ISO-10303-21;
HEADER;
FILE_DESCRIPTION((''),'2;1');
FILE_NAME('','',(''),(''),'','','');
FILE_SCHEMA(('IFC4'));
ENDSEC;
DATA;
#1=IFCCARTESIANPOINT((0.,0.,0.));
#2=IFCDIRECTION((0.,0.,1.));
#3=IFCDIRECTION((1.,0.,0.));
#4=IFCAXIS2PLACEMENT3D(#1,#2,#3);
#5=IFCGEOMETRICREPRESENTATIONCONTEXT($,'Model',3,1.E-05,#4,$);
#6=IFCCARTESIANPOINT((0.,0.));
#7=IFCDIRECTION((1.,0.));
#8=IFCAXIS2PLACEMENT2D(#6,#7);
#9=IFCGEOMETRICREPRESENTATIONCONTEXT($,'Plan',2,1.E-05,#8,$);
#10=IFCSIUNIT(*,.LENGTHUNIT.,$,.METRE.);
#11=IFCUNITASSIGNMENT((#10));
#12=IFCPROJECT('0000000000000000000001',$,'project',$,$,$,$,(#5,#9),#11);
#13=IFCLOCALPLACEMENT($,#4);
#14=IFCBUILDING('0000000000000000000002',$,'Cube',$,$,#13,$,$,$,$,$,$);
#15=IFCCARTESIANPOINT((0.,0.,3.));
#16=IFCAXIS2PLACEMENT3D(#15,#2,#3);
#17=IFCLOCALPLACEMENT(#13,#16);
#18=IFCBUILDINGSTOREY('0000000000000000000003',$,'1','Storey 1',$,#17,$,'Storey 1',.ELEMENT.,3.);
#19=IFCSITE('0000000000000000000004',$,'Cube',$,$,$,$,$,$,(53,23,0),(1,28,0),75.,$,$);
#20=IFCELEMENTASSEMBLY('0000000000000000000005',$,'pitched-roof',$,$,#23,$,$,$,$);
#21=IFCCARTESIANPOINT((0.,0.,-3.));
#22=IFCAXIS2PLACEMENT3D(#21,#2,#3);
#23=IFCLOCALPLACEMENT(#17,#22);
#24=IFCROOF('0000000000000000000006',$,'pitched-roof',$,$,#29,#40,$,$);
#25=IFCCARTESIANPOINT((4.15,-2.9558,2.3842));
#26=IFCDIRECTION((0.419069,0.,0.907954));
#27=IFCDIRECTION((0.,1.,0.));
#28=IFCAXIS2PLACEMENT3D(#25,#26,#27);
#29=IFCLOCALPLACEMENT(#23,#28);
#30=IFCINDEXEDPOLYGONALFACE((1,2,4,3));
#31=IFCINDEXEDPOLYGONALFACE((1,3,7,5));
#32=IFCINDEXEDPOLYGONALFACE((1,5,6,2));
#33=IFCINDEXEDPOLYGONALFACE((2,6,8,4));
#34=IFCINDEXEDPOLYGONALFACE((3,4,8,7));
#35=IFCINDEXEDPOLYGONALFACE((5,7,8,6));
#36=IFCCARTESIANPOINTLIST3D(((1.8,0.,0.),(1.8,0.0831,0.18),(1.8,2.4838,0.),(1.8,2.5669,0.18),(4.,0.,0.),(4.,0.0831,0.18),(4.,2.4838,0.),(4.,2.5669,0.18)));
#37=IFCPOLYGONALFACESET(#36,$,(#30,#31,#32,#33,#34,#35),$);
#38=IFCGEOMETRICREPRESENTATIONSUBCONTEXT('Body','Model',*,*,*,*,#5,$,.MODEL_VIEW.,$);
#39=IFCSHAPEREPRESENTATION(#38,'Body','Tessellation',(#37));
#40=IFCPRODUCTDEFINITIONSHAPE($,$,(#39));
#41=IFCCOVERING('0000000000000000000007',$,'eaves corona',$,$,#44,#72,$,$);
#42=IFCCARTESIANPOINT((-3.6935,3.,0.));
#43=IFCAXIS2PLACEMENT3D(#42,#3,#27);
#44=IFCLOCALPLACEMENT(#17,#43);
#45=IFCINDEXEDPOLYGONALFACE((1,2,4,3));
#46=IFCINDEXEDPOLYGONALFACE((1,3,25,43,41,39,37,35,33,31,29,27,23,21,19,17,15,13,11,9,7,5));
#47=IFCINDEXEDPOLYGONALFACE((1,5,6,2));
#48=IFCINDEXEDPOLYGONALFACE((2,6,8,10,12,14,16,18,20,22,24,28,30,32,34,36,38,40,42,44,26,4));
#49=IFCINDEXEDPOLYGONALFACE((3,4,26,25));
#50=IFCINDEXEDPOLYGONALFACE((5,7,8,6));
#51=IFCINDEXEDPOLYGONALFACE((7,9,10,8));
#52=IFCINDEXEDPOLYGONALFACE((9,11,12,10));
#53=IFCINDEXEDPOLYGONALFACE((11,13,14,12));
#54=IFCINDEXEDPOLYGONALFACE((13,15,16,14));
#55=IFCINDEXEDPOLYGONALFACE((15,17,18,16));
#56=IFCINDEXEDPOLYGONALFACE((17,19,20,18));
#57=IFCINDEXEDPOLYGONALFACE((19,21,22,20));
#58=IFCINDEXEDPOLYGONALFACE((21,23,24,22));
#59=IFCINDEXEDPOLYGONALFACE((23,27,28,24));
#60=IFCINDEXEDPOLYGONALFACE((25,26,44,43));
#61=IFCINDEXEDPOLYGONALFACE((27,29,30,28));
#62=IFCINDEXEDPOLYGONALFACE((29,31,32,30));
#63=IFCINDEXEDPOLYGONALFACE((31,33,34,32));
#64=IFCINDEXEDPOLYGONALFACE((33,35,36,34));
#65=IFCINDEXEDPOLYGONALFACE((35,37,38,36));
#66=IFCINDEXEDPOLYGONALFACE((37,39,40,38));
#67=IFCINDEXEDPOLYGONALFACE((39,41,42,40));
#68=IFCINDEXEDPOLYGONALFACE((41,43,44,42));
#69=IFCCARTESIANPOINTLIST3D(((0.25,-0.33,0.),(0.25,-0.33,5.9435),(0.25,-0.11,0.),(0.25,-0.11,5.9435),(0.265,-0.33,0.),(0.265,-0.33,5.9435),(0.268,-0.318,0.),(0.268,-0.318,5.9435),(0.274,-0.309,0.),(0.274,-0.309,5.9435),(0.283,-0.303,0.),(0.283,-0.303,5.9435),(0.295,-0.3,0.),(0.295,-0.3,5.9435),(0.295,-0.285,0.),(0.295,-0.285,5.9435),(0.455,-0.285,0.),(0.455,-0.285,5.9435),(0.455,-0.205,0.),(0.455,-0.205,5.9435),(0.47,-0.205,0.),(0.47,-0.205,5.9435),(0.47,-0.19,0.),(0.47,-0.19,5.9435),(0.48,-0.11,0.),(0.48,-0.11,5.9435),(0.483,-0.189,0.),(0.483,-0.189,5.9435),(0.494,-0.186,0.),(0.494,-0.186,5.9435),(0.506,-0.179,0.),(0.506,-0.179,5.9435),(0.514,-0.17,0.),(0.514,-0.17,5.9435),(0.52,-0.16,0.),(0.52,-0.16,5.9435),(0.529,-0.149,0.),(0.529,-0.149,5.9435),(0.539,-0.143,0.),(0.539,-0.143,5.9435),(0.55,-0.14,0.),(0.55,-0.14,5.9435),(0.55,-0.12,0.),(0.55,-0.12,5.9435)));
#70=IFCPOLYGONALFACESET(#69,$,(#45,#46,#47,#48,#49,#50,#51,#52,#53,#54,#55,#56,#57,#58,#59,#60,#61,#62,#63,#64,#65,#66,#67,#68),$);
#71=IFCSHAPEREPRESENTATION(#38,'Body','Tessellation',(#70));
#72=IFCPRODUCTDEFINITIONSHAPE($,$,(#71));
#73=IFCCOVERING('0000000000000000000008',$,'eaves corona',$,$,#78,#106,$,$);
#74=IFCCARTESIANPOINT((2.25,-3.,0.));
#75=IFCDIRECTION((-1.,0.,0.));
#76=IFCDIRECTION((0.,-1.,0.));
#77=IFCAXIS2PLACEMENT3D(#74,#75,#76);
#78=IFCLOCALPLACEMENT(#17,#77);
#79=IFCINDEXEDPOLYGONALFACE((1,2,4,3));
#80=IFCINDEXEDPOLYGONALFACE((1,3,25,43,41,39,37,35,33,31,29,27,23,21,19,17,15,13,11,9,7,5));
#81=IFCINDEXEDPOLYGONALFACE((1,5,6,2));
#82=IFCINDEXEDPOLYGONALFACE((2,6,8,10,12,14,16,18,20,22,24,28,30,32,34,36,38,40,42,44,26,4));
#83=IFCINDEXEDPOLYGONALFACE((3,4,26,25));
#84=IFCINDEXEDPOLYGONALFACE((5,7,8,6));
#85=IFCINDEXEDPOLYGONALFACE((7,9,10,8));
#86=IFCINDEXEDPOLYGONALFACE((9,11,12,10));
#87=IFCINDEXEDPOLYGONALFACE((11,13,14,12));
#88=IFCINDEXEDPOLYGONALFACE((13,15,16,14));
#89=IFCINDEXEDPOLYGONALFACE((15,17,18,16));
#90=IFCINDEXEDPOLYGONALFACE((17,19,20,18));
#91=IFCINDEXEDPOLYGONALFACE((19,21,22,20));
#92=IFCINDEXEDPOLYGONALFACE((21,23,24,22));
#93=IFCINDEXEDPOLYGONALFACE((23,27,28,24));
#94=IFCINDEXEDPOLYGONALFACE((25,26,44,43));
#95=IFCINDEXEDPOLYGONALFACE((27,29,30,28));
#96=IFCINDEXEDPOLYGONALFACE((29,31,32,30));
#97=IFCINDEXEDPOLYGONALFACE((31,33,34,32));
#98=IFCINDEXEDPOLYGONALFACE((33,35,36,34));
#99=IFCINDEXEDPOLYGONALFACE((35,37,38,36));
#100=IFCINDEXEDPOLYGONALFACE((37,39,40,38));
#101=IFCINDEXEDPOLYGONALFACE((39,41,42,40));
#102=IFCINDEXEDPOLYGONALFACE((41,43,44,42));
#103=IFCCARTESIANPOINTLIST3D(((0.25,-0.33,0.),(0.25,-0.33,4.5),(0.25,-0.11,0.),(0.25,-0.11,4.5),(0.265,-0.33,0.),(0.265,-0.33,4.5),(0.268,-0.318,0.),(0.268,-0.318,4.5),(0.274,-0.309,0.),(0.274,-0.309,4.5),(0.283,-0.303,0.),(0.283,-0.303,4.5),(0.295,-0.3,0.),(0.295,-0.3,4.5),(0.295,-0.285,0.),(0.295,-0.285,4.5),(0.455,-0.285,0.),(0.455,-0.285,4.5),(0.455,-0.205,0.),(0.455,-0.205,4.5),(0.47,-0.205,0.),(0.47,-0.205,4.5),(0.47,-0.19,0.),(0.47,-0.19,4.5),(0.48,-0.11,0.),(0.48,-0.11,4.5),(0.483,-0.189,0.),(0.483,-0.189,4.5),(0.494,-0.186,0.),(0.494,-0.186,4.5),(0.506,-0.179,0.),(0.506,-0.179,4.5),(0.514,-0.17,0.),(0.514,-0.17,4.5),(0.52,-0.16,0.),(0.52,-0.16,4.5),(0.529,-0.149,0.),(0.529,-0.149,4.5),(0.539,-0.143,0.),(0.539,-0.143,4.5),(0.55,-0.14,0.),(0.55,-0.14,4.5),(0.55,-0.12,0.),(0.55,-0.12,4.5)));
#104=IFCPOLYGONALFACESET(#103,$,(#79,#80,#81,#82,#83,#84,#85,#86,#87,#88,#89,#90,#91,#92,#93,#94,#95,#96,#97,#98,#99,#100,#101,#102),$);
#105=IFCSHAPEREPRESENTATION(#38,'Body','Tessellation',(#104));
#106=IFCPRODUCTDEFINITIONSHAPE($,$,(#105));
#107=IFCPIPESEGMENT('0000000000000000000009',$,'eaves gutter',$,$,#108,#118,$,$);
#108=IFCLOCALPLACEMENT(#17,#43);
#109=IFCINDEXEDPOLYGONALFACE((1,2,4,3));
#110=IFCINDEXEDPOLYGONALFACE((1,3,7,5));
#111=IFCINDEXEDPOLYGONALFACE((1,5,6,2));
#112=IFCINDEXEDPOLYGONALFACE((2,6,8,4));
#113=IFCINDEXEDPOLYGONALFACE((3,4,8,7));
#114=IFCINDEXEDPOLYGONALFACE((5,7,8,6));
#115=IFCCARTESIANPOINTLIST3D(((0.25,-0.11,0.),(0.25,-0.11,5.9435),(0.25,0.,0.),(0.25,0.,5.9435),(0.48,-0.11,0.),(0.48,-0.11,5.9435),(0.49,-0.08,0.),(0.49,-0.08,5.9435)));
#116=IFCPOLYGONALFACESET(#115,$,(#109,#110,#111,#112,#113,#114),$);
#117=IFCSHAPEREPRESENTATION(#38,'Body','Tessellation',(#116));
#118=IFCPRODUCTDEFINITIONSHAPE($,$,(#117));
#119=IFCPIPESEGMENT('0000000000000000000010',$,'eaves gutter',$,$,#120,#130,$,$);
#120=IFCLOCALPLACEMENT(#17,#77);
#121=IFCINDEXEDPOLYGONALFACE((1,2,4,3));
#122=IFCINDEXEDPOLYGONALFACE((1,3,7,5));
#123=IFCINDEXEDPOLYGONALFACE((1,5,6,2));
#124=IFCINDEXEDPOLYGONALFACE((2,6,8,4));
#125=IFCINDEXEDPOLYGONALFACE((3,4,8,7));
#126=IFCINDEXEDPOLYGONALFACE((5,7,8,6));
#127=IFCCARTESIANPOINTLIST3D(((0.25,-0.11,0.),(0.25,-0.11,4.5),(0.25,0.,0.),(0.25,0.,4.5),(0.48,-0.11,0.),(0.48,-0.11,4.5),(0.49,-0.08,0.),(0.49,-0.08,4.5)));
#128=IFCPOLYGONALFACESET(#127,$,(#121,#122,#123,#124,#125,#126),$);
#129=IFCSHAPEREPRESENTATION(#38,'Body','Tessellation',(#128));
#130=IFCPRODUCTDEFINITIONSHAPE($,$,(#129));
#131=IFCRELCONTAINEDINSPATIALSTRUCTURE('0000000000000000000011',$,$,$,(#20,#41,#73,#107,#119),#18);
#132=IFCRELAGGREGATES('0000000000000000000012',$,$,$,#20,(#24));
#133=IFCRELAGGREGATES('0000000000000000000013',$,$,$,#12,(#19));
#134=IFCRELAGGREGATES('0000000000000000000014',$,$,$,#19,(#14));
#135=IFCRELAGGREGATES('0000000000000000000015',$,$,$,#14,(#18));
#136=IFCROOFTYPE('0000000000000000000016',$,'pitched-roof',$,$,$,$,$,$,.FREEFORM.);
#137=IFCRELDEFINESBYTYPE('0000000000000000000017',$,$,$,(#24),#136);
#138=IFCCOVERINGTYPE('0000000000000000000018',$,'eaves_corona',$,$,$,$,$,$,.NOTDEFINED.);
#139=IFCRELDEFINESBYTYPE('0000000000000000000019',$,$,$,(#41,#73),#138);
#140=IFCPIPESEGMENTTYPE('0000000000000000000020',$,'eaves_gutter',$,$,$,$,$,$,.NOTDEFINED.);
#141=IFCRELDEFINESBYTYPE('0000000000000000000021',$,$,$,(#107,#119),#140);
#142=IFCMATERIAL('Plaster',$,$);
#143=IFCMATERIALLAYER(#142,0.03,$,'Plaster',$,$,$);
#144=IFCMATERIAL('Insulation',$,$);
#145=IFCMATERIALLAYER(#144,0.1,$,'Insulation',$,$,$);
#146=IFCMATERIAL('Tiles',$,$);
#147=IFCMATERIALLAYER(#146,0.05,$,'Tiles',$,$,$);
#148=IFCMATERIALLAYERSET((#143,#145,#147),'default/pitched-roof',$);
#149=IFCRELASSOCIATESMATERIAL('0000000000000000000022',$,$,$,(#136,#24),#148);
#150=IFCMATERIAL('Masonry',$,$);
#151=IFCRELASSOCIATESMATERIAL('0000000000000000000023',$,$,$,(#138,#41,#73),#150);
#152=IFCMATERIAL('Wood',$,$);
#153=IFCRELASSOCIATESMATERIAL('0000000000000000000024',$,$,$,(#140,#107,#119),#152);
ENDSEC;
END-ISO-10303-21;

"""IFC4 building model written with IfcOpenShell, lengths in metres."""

from ifc_helpers import new_model, si_unit, frame, origin_with_axes, origin_2d_with_axis, place, context, subcontext, project, spatial, polyline, indexed_curve, outline, extrude, material, layer, layer_set, layer_usage, material_profile, profile_set, profile_usage, type_object, element, aggregate, save


model = new_model("IFC4")

# Units and contexts
model_context = context("Model", 3, precision=1e-05, world=origin_with_axes())
plan_context = context("Plan", 2, precision=1e-05, world=origin_2d_with_axis())
body_context = subcontext(model_context, "Body", "Model", "MODEL_VIEW")
ifc_project = project(units=[si_unit("LENGTHUNIT", "METRE")], contexts=[model_context, plan_context])

# Site, building, storey
site = spatial("IfcSite", under=ifc_project, Name="Cube", RefLatitude=(53, 23, 0), RefLongitude=(1, 28, 0), RefElevation=75.0)
building_placement = place(None, origin_with_axes())
building = spatial("IfcBuilding", under=site, at=building_placement, Name="Cube")
storey_placement = place(building_placement, frame((0.0, 0.0, 3.0), z_axis=(0.0, 0.0, 1.0), x_axis=(1.0, 0.0, 0.0)))
storey = spatial("IfcBuildingStorey", under=building, at=storey_placement, Name="1", Description="Storey 1", LongName="Storey 1", CompositionType="ELEMENT", Elevation=3.0)

# Element assembly, roof
assembly_placement = place(storey_placement, frame((0.0, 0.0, -3.0), z_axis=(0.0, 0.0, 1.0), x_axis=(1.0, 0.0, 0.0)))
assembly = element("IfcElementAssembly", 1, at=assembly_placement, inside=storey, Name="pitched-roof")
ifc_material_1 = material(Name="Plaster")
ifc_layer_1 = layer(ifc_material_1, 0.03, Name="Plaster")
ifc_material_2 = material(Name="Insulation")
ifc_layer_2 = layer(ifc_material_2, 0.1, Name="Insulation")
ifc_material_3 = material(Name="Tiles")
ifc_layer_3 = layer(ifc_material_3, 0.05, Name="Tiles")
ifc_layer_set = layer_set([ifc_layer_1, ifc_layer_2, ifc_layer_3], Name="default/pitched-roof")
roof_type = type_object("IfcRoofType", Name="pitched-roof", PredefinedType="FREEFORM", material=ifc_layer_set)
ifc_layer_usage_1 = layer_usage(ifc_layer_set, "AXIS3", "POSITIVE", 0.0)
roof_1_placement = place(assembly_placement, frame((4.15, -2.9558, 2.3842), z_axis=(0.419069, 0.0, 0.907954), x_axis=(0.0, 1.0, 0.0)))
roof_1 = element("IfcRoof", 2, at=roof_1_placement, type_object=roof_type, material=ifc_layer_usage_1, Name="pitched-roof", context=body_context, shape_type="SweptSolid", body=[
    extrude(outline(indexed_curve([(4.0, 2.4838), (4.0, 0.0), (1.8, 0.0), (1.8, 2.4838)])), frame((0.0, 0.0, 0.0), z_axis=(0.0, 0.0, 1.0), x_axis=(1.0, 0.0, 0.0)), (0.0, 0.419069, 0.907954), 0.1982),
])
aggregate(assembly, [roof_1])

# Coverings
ifc_material_4 = material(Name="Masonry")
ifc_material_profile_1 = material_profile(ifc_material_4, outline(polyline([(0.25, -0.11), (0.25, -0.33), (0.265, -0.33), (0.268, -0.318), (0.274, -0.309), (0.283, -0.303), (0.295, -0.3), (0.295, -0.285), (0.455, -0.285), (0.455, -0.205), (0.47, -0.205), (0.47, -0.19), (0.483, -0.189), (0.494, -0.186), (0.506, -0.179), (0.514, -0.17), (0.52, -0.16), (0.529, -0.149), (0.539, -0.143), (0.55, -0.14), (0.55, -0.12), (0.48, -0.11), (0.25, -0.11)])))
ifc_profile_set_1 = profile_set([ifc_material_profile_1])
ifc_profile_usage_1 = profile_usage(ifc_profile_set_1)
covering_type_1 = type_object("IfcCoveringType", Name="eaves_corona", PredefinedType="NOTDEFINED", material=ifc_profile_set_1)
covering_1_placement = place(storey_placement, frame((-3.6935, 3.0, 0.0), z_axis=(1.0, 0.0, 0.0), x_axis=(0.0, 1.0, 0.0)))
element("IfcCovering", 3, at=covering_1_placement, inside=storey, type_object=covering_type_1, material=ifc_profile_usage_1, Name="eaves corona", context=body_context, shape_type="SweptSolid", body=[
    extrude(outline(polyline([(0.25, -0.11), (0.25, -0.33), (0.265, -0.33), (0.268, -0.318), (0.274, -0.309), (0.283, -0.303), (0.295, -0.3), (0.295, -0.285), (0.455, -0.285), (0.455, -0.205), (0.47, -0.205), (0.47, -0.19), (0.483, -0.189), (0.494, -0.186), (0.506, -0.179), (0.514, -0.17), (0.52, -0.16), (0.529, -0.149), (0.539, -0.143), (0.55, -0.14), (0.55, -0.12), (0.48, -0.11), (0.25, -0.11)])), origin_with_axes(), (0.0, 0.0, 1.0), 5.9435),
])
ifc_profile_usage_2 = profile_usage(ifc_profile_set_1)
covering_2_placement = place(storey_placement, frame((2.25, -3.0, 0.0), z_axis=(-1.0, 0.0, 0.0), x_axis=(0.0, -1.0, 0.0)))
element("IfcCovering", 4, at=covering_2_placement, inside=storey, type_object=covering_type_1, material=ifc_profile_usage_2, Name="eaves corona", context=body_context, shape_type="SweptSolid", body=[
    extrude(outline(polyline([(0.25, -0.11), (0.25, -0.33), (0.265, -0.33), (0.268, -0.318), (0.274, -0.309), (0.283, -0.303), (0.295, -0.3), (0.295, -0.285), (0.455, -0.285), (0.455, -0.205), (0.47, -0.205), (0.47, -0.19), (0.483, -0.189), (0.494, -0.186), (0.506, -0.179), (0.514, -0.17), (0.52, -0.16), (0.529, -0.149), (0.539, -0.143), (0.55, -0.14), (0.55, -0.12), (0.48, -0.11), (0.25, -0.11)])), origin_with_axes(), (0.0, 0.0, 1.0), 4.5),
])

# Pipe segments
ifc_material_5 = material(Name="Wood")
ifc_material_profile_2 = material_profile(ifc_material_5, outline(polyline([(0.25, -0.11), (0.48, -0.11), (0.49, -0.08), (0.25, 0.0), (0.25, -0.11)])))
ifc_profile_set_2 = profile_set([ifc_material_profile_2])
ifc_profile_usage_3 = profile_usage(ifc_profile_set_2)
pipe_segment_type = type_object("IfcPipeSegmentType", Name="eaves_gutter", PredefinedType="NOTDEFINED", material=ifc_profile_set_2)
pipe_segment_1_placement = place(storey_placement, frame((-3.6935, 3.0, 0.0), z_axis=(1.0, 0.0, 0.0), x_axis=(0.0, 1.0, 0.0)))
element("IfcPipeSegment", 5, at=pipe_segment_1_placement, inside=storey, type_object=pipe_segment_type, material=ifc_profile_usage_3, Name="eaves gutter", context=body_context, shape_type="SweptSolid", body=[
    extrude(outline(polyline([(0.25, -0.11), (0.48, -0.11), (0.49, -0.08), (0.25, 0.0), (0.25, -0.11)])), origin_with_axes(), (0.0, 0.0, 1.0), 5.9435),
])
ifc_profile_usage_4 = profile_usage(ifc_profile_set_2)
pipe_segment_2_placement = place(storey_placement, frame((2.25, -3.0, 0.0), z_axis=(-1.0, 0.0, 0.0), x_axis=(0.0, -1.0, 0.0)))
element("IfcPipeSegment", 6, at=pipe_segment_2_placement, inside=storey, type_object=pipe_segment_type, material=ifc_profile_usage_4, Name="eaves gutter", context=body_context, shape_type="SweptSolid", body=[
    extrude(outline(polyline([(0.25, -0.11), (0.48, -0.11), (0.49, -0.08), (0.25, 0.0), (0.25, -0.11)])), origin_with_axes(), (0.0, 0.0, 1.0), 4.5),
])

save(model, "model.ifc")
